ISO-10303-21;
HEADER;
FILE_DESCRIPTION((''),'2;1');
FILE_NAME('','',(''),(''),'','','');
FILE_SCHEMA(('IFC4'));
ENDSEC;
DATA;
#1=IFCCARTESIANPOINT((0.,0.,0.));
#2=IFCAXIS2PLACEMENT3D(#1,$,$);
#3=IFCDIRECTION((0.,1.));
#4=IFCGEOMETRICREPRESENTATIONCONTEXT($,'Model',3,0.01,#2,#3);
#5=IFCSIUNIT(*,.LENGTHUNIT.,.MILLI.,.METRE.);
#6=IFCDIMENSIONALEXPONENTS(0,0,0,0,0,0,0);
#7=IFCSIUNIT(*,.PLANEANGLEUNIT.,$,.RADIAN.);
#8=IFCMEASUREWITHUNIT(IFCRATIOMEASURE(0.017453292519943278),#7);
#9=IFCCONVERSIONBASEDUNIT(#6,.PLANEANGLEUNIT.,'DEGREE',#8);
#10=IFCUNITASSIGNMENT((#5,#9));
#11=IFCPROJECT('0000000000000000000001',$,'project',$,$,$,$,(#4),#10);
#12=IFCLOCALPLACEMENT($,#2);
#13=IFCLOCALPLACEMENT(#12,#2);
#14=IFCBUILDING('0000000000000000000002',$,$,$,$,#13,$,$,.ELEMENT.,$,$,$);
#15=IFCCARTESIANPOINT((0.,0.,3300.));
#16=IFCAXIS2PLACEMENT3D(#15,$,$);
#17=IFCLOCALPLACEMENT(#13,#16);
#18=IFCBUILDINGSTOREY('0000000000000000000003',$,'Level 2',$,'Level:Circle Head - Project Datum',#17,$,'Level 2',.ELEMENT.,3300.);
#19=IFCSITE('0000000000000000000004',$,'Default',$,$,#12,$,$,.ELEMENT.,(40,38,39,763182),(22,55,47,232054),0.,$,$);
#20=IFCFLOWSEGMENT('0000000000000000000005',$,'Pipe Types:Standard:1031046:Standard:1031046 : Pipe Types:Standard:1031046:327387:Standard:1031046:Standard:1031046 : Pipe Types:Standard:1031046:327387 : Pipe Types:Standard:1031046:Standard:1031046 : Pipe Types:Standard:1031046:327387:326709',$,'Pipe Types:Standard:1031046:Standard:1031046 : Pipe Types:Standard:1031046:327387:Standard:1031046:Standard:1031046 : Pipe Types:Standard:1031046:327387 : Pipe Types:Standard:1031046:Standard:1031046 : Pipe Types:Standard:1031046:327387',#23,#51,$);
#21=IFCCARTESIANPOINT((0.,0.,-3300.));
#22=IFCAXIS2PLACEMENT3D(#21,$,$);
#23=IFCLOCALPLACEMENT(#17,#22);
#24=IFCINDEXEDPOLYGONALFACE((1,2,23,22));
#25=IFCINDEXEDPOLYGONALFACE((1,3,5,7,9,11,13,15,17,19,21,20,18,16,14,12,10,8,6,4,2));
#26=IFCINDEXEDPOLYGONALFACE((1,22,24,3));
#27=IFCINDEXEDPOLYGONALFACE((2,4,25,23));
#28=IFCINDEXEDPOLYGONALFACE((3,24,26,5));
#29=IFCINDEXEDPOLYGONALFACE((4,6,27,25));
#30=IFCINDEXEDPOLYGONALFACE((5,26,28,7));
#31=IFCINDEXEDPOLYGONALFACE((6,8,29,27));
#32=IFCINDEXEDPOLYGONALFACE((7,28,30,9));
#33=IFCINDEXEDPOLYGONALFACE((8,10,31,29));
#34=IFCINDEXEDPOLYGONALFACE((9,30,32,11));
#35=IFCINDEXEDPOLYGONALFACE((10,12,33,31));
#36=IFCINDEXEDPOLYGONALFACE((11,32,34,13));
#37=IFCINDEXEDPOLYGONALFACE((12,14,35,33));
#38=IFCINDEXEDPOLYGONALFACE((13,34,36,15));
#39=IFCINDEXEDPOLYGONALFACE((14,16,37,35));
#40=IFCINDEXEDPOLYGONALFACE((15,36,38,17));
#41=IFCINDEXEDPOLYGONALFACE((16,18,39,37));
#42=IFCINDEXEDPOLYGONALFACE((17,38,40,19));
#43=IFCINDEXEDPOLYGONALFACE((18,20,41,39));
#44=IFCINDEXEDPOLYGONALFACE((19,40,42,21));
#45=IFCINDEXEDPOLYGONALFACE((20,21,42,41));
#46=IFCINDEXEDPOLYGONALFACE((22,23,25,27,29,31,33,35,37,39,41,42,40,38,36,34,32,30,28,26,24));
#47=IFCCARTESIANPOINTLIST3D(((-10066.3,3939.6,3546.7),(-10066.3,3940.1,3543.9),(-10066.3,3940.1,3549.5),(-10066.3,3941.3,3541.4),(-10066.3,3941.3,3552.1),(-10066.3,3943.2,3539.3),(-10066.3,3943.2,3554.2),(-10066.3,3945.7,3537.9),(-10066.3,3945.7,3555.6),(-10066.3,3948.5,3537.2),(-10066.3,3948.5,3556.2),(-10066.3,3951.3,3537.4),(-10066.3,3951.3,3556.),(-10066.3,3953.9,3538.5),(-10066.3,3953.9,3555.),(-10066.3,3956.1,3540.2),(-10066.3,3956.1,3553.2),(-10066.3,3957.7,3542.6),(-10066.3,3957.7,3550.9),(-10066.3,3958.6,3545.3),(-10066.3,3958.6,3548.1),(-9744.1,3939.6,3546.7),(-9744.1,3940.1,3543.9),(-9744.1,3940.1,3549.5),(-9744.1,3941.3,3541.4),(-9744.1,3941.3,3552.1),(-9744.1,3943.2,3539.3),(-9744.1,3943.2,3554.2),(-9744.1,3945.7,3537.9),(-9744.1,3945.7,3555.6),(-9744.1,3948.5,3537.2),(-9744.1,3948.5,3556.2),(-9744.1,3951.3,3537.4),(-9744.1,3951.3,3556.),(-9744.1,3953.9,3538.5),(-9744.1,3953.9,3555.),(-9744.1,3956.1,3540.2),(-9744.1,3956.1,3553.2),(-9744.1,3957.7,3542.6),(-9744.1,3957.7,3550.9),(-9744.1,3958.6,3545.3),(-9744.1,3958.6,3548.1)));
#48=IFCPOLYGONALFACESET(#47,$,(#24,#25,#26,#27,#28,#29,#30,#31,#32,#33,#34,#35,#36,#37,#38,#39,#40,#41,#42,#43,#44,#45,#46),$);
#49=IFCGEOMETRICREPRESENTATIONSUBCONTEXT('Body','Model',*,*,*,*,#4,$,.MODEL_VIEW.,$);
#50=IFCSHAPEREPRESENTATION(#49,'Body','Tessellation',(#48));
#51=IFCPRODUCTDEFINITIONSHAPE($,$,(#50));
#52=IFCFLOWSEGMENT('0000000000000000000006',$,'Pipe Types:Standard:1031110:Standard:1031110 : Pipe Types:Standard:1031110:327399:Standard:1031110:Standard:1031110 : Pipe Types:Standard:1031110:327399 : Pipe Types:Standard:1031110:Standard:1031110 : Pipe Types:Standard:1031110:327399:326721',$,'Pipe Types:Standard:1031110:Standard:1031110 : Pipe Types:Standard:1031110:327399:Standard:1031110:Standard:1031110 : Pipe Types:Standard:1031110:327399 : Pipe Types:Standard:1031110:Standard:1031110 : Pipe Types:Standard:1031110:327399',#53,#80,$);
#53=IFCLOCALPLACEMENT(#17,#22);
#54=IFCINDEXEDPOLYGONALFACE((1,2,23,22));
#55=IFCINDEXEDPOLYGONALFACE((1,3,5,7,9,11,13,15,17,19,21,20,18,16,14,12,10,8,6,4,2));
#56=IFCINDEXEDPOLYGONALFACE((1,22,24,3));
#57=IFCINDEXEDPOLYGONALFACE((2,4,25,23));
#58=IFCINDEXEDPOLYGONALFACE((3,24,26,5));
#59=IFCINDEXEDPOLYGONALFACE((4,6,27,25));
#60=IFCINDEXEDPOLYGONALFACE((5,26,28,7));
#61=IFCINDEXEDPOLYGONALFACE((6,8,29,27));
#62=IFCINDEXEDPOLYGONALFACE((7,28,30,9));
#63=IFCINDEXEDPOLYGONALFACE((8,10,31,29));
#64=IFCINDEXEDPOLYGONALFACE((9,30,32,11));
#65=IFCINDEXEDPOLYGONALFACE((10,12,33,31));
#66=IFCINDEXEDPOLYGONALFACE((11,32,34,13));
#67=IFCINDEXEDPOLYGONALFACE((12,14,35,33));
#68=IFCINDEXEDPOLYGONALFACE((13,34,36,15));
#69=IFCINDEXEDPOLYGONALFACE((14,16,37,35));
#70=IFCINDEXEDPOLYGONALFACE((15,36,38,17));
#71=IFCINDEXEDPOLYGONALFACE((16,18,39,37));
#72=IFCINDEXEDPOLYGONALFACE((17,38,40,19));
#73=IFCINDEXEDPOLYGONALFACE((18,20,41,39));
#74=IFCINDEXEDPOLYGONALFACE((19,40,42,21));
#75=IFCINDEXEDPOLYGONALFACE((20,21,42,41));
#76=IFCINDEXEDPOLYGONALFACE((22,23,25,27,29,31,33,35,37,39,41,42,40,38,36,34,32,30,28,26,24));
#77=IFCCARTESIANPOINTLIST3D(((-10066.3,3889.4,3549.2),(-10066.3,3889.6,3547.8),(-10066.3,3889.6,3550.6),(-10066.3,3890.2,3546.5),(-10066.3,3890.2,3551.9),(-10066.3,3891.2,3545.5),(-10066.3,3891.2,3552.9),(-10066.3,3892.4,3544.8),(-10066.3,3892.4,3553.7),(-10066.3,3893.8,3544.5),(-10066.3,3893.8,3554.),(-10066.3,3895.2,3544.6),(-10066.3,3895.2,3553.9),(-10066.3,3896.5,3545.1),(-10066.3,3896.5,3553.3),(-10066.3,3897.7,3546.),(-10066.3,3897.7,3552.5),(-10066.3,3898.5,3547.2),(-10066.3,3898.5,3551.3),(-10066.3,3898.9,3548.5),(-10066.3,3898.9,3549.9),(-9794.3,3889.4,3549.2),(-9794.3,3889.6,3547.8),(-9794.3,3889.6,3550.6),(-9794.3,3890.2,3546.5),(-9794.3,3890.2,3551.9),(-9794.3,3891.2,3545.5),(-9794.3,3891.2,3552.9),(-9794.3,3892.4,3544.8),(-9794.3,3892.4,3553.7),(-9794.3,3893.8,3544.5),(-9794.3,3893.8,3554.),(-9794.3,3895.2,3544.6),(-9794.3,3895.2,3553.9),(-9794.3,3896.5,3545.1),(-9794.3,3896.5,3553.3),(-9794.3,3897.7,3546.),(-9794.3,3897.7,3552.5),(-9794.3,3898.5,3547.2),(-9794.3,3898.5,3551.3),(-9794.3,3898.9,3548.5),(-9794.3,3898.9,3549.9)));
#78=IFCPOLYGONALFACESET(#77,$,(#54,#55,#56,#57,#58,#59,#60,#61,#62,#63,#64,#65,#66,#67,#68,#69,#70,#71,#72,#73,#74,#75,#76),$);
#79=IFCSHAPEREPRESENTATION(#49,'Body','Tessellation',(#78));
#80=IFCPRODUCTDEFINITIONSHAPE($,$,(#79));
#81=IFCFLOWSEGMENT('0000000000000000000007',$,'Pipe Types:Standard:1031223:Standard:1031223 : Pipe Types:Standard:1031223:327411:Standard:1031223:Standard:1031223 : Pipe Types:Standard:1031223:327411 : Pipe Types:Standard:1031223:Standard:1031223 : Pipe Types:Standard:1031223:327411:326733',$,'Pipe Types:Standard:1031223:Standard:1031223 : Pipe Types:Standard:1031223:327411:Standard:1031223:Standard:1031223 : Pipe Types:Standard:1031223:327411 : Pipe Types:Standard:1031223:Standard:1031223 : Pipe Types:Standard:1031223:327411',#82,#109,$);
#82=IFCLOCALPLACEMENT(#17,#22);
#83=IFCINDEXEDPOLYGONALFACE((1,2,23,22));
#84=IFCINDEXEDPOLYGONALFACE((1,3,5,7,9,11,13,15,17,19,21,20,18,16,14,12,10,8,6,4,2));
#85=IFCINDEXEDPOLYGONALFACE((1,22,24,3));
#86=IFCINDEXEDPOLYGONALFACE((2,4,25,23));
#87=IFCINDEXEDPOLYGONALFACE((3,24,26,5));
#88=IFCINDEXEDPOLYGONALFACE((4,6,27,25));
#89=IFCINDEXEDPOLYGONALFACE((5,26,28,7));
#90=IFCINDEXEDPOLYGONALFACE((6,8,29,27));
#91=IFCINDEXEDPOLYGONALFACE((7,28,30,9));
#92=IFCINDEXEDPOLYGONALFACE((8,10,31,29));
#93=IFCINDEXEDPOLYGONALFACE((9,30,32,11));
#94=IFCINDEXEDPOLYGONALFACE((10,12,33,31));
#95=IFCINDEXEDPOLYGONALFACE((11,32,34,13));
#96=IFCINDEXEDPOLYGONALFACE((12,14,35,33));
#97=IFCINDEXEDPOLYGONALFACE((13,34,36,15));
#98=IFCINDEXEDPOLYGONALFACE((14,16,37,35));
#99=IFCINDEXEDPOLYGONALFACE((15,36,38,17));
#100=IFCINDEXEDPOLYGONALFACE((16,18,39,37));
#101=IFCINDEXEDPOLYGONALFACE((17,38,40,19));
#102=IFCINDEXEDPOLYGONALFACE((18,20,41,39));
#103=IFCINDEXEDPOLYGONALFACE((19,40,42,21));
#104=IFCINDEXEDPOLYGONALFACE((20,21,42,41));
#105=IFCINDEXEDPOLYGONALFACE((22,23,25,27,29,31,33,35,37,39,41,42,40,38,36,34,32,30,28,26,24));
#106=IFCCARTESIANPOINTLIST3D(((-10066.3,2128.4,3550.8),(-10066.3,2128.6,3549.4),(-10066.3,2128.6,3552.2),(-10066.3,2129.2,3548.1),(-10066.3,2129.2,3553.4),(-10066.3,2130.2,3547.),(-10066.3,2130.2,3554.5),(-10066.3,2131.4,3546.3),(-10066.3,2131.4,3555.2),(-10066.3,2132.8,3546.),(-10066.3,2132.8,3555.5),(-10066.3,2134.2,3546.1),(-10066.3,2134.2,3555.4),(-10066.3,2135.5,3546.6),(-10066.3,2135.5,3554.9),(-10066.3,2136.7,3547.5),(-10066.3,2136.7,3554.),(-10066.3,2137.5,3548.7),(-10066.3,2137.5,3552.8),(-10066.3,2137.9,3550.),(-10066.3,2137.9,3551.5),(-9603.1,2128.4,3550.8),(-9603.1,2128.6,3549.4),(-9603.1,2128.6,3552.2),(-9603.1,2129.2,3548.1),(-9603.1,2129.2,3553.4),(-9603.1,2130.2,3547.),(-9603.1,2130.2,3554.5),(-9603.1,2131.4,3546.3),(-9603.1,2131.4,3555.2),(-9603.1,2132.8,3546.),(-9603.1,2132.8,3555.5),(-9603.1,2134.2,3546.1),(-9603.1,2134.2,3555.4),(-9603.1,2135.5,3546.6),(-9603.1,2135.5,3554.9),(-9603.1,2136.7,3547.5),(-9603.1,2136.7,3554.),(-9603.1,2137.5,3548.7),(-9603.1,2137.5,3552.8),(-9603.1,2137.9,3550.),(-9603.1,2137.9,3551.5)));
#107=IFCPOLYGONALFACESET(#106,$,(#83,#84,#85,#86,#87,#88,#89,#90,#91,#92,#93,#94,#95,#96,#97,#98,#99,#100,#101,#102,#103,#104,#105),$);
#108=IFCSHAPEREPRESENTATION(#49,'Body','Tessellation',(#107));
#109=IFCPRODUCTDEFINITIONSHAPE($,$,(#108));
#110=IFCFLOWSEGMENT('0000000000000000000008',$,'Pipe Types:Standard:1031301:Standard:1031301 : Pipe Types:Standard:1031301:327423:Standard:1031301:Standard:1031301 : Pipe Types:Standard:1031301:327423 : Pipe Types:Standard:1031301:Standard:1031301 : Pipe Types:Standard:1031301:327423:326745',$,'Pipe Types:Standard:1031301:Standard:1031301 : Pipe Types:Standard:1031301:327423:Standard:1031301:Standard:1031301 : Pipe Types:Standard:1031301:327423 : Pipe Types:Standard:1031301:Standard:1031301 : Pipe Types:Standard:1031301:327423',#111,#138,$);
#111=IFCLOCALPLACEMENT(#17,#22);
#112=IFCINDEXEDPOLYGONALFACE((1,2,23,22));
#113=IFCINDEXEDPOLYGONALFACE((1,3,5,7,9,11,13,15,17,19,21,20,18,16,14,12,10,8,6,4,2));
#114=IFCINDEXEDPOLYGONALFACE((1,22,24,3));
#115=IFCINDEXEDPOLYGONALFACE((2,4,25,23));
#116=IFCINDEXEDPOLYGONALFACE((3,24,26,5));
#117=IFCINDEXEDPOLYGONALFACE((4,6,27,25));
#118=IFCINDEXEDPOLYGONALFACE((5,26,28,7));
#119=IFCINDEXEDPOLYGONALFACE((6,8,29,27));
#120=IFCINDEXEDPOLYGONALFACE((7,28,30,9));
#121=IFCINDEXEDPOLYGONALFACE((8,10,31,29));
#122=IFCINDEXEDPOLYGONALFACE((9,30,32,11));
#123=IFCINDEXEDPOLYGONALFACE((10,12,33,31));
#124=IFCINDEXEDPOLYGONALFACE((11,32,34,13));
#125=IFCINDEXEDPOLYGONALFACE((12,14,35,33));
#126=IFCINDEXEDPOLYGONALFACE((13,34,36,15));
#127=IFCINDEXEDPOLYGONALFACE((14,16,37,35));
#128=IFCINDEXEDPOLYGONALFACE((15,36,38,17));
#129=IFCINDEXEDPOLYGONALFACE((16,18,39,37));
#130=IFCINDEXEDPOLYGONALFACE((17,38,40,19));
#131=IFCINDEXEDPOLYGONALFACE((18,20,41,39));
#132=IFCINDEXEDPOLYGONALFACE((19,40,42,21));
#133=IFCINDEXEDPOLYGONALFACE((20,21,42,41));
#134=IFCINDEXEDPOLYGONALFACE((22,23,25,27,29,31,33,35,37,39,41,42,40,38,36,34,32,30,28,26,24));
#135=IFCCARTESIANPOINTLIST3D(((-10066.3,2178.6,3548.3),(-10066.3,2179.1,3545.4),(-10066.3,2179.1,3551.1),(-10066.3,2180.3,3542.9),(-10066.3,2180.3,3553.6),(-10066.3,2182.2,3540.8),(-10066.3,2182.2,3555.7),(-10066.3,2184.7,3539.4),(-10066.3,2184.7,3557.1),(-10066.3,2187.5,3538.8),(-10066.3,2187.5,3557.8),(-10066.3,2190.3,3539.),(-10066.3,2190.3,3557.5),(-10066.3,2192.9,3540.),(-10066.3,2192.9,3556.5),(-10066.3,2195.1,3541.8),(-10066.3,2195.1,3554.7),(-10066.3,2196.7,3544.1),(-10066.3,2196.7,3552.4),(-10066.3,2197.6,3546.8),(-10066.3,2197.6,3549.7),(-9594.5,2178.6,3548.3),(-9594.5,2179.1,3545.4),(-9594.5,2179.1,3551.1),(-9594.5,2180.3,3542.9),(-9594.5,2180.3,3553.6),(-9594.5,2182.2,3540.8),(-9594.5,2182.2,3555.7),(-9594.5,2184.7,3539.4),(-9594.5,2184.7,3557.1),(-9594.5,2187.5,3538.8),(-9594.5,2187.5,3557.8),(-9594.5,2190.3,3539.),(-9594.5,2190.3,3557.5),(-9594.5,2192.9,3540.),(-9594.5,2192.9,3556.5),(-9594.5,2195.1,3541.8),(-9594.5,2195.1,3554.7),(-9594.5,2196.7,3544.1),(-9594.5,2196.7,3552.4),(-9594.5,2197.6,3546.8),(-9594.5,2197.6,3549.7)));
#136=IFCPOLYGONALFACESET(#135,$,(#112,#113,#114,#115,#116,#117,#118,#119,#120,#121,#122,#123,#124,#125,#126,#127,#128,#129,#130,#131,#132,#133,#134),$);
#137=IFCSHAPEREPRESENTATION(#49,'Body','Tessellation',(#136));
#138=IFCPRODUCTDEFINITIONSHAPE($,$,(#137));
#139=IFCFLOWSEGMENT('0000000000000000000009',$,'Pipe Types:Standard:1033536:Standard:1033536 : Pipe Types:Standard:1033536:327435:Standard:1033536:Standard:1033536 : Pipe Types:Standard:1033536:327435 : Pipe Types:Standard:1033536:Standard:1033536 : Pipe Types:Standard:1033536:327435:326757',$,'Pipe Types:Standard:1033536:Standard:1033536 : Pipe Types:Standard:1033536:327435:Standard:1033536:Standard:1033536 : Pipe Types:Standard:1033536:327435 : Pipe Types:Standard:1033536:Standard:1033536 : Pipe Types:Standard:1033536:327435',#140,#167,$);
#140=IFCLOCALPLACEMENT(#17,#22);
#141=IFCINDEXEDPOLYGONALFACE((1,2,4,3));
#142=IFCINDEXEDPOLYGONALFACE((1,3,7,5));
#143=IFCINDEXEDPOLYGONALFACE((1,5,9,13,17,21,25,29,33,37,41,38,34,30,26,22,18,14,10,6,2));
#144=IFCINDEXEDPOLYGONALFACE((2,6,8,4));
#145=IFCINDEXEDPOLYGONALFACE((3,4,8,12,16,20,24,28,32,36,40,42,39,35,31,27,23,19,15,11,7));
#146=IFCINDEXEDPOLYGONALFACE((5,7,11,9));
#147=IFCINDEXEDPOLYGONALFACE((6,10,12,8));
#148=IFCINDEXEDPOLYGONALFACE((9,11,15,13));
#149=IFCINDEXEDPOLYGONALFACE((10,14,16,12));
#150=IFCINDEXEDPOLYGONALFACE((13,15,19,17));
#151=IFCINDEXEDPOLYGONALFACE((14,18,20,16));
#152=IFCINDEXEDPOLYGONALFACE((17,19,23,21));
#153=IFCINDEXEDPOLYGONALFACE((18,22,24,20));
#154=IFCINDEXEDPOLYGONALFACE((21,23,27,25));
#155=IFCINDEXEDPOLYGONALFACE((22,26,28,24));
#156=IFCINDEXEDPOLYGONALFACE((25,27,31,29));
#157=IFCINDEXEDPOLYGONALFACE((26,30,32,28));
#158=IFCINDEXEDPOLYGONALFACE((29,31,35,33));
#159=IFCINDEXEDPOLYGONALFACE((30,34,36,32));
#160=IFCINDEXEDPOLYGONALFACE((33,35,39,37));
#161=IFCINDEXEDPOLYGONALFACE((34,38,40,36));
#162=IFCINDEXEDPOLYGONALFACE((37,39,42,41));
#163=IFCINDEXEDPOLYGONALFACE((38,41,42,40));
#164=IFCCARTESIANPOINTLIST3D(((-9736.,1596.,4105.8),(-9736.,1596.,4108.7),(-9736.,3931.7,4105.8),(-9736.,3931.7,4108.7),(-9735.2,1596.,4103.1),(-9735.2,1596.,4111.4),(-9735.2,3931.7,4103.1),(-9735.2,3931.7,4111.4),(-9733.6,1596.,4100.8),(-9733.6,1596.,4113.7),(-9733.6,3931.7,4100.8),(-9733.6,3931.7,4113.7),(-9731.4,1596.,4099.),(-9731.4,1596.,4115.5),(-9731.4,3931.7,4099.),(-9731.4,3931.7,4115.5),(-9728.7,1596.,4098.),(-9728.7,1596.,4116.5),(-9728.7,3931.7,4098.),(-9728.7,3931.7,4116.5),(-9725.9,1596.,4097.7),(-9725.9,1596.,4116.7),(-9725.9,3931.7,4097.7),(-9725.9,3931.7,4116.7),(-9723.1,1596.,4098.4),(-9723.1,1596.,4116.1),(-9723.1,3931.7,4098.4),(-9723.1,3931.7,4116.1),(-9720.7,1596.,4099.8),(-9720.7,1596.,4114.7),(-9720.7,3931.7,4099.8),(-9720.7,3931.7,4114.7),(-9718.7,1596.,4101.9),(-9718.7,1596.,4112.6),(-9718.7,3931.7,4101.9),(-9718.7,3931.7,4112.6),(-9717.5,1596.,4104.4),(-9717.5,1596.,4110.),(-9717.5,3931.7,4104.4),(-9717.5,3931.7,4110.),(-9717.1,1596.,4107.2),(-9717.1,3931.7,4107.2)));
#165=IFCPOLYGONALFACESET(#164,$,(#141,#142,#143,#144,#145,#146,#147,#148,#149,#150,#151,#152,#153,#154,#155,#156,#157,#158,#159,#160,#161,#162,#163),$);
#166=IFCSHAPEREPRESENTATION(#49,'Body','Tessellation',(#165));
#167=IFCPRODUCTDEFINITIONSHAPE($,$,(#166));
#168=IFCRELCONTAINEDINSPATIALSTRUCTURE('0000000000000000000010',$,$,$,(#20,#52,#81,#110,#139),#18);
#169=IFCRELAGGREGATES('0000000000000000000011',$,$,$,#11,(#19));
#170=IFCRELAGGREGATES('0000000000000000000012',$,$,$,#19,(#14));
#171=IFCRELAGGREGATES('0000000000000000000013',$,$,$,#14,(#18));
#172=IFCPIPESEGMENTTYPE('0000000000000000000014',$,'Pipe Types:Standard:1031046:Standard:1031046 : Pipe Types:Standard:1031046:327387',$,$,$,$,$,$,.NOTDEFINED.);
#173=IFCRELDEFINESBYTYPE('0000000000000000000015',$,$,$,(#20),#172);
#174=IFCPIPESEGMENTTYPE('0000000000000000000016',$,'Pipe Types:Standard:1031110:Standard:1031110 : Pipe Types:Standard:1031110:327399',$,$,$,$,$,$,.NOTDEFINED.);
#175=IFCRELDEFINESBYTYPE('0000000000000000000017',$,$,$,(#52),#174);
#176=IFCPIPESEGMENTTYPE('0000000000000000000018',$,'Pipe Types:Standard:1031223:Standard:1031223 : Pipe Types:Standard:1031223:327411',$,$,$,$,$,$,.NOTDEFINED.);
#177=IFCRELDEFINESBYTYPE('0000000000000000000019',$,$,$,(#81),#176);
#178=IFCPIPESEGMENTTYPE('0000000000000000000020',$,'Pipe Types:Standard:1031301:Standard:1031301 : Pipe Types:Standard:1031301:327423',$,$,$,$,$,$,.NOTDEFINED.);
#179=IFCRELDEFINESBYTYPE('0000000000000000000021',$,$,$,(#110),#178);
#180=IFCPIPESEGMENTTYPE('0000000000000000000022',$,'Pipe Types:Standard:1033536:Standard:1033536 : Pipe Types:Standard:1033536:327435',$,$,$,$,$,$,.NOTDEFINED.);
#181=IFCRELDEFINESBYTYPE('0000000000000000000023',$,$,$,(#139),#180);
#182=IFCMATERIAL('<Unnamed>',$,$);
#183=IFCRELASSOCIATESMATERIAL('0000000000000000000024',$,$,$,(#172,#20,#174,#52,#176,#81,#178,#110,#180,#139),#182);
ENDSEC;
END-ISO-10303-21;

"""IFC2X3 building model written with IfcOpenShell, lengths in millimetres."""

from ifc_helpers import new_model, entity, si_unit, converted_unit, direction, frame, origin, origin_2d_with_axis, place, context, subcontext, project, spatial, circle, extrude, source, transform, mapped, material, type_object, type_shapes, element, save


model = new_model("IFC2X3")

# Units and contexts
model_context = context("Model", 3, precision=0.01, world=origin(), true_north=direction((0.0, 1.0)))
body_context = subcontext(model_context, "Body", "Model", "MODEL_VIEW")
ifc_project = project(units=[si_unit("LENGTHUNIT", "METRE", prefix="MILLI"), converted_unit("PLANEANGLEUNIT", "DEGREE", entity("IfcRatioMeasure", 0.017453292519943278), si_unit("PLANEANGLEUNIT", "RADIAN"), dimensions=[0, 0, 0, 0, 0, 0, 0])], contexts=[model_context])

# Site, building, storey
site_placement = place(None, origin())
site = spatial("IfcSite", under=ifc_project, at=site_placement, Name="Default", CompositionType="ELEMENT", RefLatitude=(40, 38, 39, 763182), RefLongitude=(22, 55, 47, 232054), RefElevation=0.0)
building_placement = place(site_placement, origin())
building = spatial("IfcBuilding", under=site, at=building_placement, CompositionType="ELEMENT")
storey_placement = place(building_placement, frame((0.0, 0.0, 3300.0)))
storey = spatial("IfcBuildingStorey", under=building, at=storey_placement, Name="Level 2", ObjectType="Level:Circle Head - Project Datum", LongName="Level 2", CompositionType="ELEMENT", Elevation=3300.0)

# Flow segments
ifc_material_1 = material(Name="<Unnamed>")
pipe_segment_type_1 = type_object("IfcPipeSegmentType", Name="Pipe Types:Standard:1031046:Standard:1031046 : Pipe Types:Standard:1031046:327387", PredefinedType="NOTDEFINED", material=ifc_material_1)
shared_shape_1 = source(origin(), body_context, "Body", "SweptSolid", [
    extrude(circle(Radius=9.5, at=origin_2d_with_axis()), frame((-10066.3, 3949.2, 3546.7), z_axis=(1.0, 0.0, 0.0), x_axis=(0.0, -1.0, 0.0)), (0.0, 0.0, 1.0), 322.3),
])
type_shapes(pipe_segment_type_1, [shared_shape_1])
flow_segment_1_placement = place(storey_placement, frame((0.0, 0.0, -3300.0)))
element("IfcFlowSegment", 1, at=flow_segment_1_placement, inside=storey, type_object=pipe_segment_type_1, material=ifc_material_1, Name="Pipe Types:Standard:1031046:Standard:1031046 : Pipe Types:Standard:1031046:327387:Standard:1031046:Standard:1031046 : Pipe Types:Standard:1031046:327387 : Pipe Types:Standard:1031046:Standard:1031046 : Pipe Types:Standard:1031046:327387:326709", ObjectType="Pipe Types:Standard:1031046:Standard:1031046 : Pipe Types:Standard:1031046:327387:Standard:1031046:Standard:1031046 : Pipe Types:Standard:1031046:327387 : Pipe Types:Standard:1031046:Standard:1031046 : Pipe Types:Standard:1031046:327387", context=body_context, shape_type="MappedRepresentation", body=[
    mapped(shared_shape_1, transform((0.0, 0.0, 0.0), scale=1.0)),
])
pipe_segment_type_2 = type_object("IfcPipeSegmentType", Name="Pipe Types:Standard:1031110:Standard:1031110 : Pipe Types:Standard:1031110:327399", PredefinedType="NOTDEFINED", material=ifc_material_1)
shared_shape_2 = source(origin(), body_context, "Body", "SweptSolid", [
    extrude(circle(Radius=4.8, at=origin_2d_with_axis()), frame((-10066.3, 3894.2, 3549.2), z_axis=(1.0, 0.0, 0.0), x_axis=(0.0, -1.0, 0.0)), (0.0, 0.0, 1.0), 272.0),
])
type_shapes(pipe_segment_type_2, [shared_shape_2])
flow_segment_2_placement = place(storey_placement, frame((0.0, 0.0, -3300.0)))
element("IfcFlowSegment", 2, at=flow_segment_2_placement, inside=storey, type_object=pipe_segment_type_2, material=ifc_material_1, Name="Pipe Types:Standard:1031110:Standard:1031110 : Pipe Types:Standard:1031110:327399:Standard:1031110:Standard:1031110 : Pipe Types:Standard:1031110:327399 : Pipe Types:Standard:1031110:Standard:1031110 : Pipe Types:Standard:1031110:327399:326721", ObjectType="Pipe Types:Standard:1031110:Standard:1031110 : Pipe Types:Standard:1031110:327399:Standard:1031110:Standard:1031110 : Pipe Types:Standard:1031110:327399 : Pipe Types:Standard:1031110:Standard:1031110 : Pipe Types:Standard:1031110:327399", context=body_context, shape_type="MappedRepresentation", body=[
    mapped(shared_shape_2, transform((0.0, 0.0, 0.0), scale=1.0)),
])
pipe_segment_type_3 = type_object("IfcPipeSegmentType", Name="Pipe Types:Standard:1031223:Standard:1031223 : Pipe Types:Standard:1031223:327411", PredefinedType="NOTDEFINED", material=ifc_material_1)
shared_shape_3 = source(origin(), body_context, "Body", "SweptSolid", [
    extrude(circle(Radius=4.8, at=origin_2d_with_axis()), frame((-10066.3, 2133.2, 3550.8), z_axis=(1.0, 0.0, 0.0), x_axis=(0.0, -1.0, 0.0)), (0.0, 0.0, 1.0), 463.3),
])
type_shapes(pipe_segment_type_3, [shared_shape_3])
flow_segment_3_placement = place(storey_placement, frame((0.0, 0.0, -3300.0)))
element("IfcFlowSegment", 3, at=flow_segment_3_placement, inside=storey, type_object=pipe_segment_type_3, material=ifc_material_1, Name="Pipe Types:Standard:1031223:Standard:1031223 : Pipe Types:Standard:1031223:327411:Standard:1031223:Standard:1031223 : Pipe Types:Standard:1031223:327411 : Pipe Types:Standard:1031223:Standard:1031223 : Pipe Types:Standard:1031223:327411:326733", ObjectType="Pipe Types:Standard:1031223:Standard:1031223 : Pipe Types:Standard:1031223:327411:Standard:1031223:Standard:1031223 : Pipe Types:Standard:1031223:327411 : Pipe Types:Standard:1031223:Standard:1031223 : Pipe Types:Standard:1031223:327411", context=body_context, shape_type="MappedRepresentation", body=[
    mapped(shared_shape_3, transform((0.0, 0.0, 0.0), scale=1.0)),
])
pipe_segment_type_4 = type_object("IfcPipeSegmentType", Name="Pipe Types:Standard:1031301:Standard:1031301 : Pipe Types:Standard:1031301:327423", PredefinedType="NOTDEFINED", material=ifc_material_1)
shared_shape_4 = source(origin(), body_context, "Body", "SweptSolid", [
    extrude(circle(Radius=9.5, at=origin_2d_with_axis()), frame((-10066.3, 2188.2, 3548.3), z_axis=(1.0, 0.0, 0.0), x_axis=(0.0, -1.0, 0.0)), (0.0, 0.0, 1.0), 471.8),
])
type_shapes(pipe_segment_type_4, [shared_shape_4])
flow_segment_4_placement = place(storey_placement, frame((0.0, 0.0, -3300.0)))
element("IfcFlowSegment", 4, at=flow_segment_4_placement, inside=storey, type_object=pipe_segment_type_4, material=ifc_material_1, Name="Pipe Types:Standard:1031301:Standard:1031301 : Pipe Types:Standard:1031301:327423:Standard:1031301:Standard:1031301 : Pipe Types:Standard:1031301:327423 : Pipe Types:Standard:1031301:Standard:1031301 : Pipe Types:Standard:1031301:327423:326745", ObjectType="Pipe Types:Standard:1031301:Standard:1031301 : Pipe Types:Standard:1031301:327423:Standard:1031301:Standard:1031301 : Pipe Types:Standard:1031301:327423 : Pipe Types:Standard:1031301:Standard:1031301 : Pipe Types:Standard:1031301:327423", context=body_context, shape_type="MappedRepresentation", body=[
    mapped(shared_shape_4, transform((0.0, 0.0, 0.0), scale=1.0)),
])
pipe_segment_type_5 = type_object("IfcPipeSegmentType", Name="Pipe Types:Standard:1033536:Standard:1033536 : Pipe Types:Standard:1033536:327435", PredefinedType="NOTDEFINED", material=ifc_material_1)
shared_shape_5 = source(origin(), body_context, "Body", "SweptSolid", [
    extrude(circle(Radius=9.5, at=origin_2d_with_axis()), frame((-9726.6, 1596.0, 4107.2), z_axis=(0.0, 1.0, 0.0), x_axis=(1.0, 0.0, 0.0)), (0.0, 0.0, 1.0), 2335.7),
])
type_shapes(pipe_segment_type_5, [shared_shape_5])
flow_segment_5_placement = place(storey_placement, frame((0.0, 0.0, -3300.0)))
element("IfcFlowSegment", 5, at=flow_segment_5_placement, inside=storey, type_object=pipe_segment_type_5, material=ifc_material_1, Name="Pipe Types:Standard:1033536:Standard:1033536 : Pipe Types:Standard:1033536:327435:Standard:1033536:Standard:1033536 : Pipe Types:Standard:1033536:327435 : Pipe Types:Standard:1033536:Standard:1033536 : Pipe Types:Standard:1033536:327435:326757", ObjectType="Pipe Types:Standard:1033536:Standard:1033536 : Pipe Types:Standard:1033536:327435:Standard:1033536:Standard:1033536 : Pipe Types:Standard:1033536:327435 : Pipe Types:Standard:1033536:Standard:1033536 : Pipe Types:Standard:1033536:327435", context=body_context, shape_type="MappedRepresentation", body=[
    mapped(shared_shape_5, transform((0.0, 0.0, 0.0), scale=1.0)),
])

save(model, "model.ifc")
